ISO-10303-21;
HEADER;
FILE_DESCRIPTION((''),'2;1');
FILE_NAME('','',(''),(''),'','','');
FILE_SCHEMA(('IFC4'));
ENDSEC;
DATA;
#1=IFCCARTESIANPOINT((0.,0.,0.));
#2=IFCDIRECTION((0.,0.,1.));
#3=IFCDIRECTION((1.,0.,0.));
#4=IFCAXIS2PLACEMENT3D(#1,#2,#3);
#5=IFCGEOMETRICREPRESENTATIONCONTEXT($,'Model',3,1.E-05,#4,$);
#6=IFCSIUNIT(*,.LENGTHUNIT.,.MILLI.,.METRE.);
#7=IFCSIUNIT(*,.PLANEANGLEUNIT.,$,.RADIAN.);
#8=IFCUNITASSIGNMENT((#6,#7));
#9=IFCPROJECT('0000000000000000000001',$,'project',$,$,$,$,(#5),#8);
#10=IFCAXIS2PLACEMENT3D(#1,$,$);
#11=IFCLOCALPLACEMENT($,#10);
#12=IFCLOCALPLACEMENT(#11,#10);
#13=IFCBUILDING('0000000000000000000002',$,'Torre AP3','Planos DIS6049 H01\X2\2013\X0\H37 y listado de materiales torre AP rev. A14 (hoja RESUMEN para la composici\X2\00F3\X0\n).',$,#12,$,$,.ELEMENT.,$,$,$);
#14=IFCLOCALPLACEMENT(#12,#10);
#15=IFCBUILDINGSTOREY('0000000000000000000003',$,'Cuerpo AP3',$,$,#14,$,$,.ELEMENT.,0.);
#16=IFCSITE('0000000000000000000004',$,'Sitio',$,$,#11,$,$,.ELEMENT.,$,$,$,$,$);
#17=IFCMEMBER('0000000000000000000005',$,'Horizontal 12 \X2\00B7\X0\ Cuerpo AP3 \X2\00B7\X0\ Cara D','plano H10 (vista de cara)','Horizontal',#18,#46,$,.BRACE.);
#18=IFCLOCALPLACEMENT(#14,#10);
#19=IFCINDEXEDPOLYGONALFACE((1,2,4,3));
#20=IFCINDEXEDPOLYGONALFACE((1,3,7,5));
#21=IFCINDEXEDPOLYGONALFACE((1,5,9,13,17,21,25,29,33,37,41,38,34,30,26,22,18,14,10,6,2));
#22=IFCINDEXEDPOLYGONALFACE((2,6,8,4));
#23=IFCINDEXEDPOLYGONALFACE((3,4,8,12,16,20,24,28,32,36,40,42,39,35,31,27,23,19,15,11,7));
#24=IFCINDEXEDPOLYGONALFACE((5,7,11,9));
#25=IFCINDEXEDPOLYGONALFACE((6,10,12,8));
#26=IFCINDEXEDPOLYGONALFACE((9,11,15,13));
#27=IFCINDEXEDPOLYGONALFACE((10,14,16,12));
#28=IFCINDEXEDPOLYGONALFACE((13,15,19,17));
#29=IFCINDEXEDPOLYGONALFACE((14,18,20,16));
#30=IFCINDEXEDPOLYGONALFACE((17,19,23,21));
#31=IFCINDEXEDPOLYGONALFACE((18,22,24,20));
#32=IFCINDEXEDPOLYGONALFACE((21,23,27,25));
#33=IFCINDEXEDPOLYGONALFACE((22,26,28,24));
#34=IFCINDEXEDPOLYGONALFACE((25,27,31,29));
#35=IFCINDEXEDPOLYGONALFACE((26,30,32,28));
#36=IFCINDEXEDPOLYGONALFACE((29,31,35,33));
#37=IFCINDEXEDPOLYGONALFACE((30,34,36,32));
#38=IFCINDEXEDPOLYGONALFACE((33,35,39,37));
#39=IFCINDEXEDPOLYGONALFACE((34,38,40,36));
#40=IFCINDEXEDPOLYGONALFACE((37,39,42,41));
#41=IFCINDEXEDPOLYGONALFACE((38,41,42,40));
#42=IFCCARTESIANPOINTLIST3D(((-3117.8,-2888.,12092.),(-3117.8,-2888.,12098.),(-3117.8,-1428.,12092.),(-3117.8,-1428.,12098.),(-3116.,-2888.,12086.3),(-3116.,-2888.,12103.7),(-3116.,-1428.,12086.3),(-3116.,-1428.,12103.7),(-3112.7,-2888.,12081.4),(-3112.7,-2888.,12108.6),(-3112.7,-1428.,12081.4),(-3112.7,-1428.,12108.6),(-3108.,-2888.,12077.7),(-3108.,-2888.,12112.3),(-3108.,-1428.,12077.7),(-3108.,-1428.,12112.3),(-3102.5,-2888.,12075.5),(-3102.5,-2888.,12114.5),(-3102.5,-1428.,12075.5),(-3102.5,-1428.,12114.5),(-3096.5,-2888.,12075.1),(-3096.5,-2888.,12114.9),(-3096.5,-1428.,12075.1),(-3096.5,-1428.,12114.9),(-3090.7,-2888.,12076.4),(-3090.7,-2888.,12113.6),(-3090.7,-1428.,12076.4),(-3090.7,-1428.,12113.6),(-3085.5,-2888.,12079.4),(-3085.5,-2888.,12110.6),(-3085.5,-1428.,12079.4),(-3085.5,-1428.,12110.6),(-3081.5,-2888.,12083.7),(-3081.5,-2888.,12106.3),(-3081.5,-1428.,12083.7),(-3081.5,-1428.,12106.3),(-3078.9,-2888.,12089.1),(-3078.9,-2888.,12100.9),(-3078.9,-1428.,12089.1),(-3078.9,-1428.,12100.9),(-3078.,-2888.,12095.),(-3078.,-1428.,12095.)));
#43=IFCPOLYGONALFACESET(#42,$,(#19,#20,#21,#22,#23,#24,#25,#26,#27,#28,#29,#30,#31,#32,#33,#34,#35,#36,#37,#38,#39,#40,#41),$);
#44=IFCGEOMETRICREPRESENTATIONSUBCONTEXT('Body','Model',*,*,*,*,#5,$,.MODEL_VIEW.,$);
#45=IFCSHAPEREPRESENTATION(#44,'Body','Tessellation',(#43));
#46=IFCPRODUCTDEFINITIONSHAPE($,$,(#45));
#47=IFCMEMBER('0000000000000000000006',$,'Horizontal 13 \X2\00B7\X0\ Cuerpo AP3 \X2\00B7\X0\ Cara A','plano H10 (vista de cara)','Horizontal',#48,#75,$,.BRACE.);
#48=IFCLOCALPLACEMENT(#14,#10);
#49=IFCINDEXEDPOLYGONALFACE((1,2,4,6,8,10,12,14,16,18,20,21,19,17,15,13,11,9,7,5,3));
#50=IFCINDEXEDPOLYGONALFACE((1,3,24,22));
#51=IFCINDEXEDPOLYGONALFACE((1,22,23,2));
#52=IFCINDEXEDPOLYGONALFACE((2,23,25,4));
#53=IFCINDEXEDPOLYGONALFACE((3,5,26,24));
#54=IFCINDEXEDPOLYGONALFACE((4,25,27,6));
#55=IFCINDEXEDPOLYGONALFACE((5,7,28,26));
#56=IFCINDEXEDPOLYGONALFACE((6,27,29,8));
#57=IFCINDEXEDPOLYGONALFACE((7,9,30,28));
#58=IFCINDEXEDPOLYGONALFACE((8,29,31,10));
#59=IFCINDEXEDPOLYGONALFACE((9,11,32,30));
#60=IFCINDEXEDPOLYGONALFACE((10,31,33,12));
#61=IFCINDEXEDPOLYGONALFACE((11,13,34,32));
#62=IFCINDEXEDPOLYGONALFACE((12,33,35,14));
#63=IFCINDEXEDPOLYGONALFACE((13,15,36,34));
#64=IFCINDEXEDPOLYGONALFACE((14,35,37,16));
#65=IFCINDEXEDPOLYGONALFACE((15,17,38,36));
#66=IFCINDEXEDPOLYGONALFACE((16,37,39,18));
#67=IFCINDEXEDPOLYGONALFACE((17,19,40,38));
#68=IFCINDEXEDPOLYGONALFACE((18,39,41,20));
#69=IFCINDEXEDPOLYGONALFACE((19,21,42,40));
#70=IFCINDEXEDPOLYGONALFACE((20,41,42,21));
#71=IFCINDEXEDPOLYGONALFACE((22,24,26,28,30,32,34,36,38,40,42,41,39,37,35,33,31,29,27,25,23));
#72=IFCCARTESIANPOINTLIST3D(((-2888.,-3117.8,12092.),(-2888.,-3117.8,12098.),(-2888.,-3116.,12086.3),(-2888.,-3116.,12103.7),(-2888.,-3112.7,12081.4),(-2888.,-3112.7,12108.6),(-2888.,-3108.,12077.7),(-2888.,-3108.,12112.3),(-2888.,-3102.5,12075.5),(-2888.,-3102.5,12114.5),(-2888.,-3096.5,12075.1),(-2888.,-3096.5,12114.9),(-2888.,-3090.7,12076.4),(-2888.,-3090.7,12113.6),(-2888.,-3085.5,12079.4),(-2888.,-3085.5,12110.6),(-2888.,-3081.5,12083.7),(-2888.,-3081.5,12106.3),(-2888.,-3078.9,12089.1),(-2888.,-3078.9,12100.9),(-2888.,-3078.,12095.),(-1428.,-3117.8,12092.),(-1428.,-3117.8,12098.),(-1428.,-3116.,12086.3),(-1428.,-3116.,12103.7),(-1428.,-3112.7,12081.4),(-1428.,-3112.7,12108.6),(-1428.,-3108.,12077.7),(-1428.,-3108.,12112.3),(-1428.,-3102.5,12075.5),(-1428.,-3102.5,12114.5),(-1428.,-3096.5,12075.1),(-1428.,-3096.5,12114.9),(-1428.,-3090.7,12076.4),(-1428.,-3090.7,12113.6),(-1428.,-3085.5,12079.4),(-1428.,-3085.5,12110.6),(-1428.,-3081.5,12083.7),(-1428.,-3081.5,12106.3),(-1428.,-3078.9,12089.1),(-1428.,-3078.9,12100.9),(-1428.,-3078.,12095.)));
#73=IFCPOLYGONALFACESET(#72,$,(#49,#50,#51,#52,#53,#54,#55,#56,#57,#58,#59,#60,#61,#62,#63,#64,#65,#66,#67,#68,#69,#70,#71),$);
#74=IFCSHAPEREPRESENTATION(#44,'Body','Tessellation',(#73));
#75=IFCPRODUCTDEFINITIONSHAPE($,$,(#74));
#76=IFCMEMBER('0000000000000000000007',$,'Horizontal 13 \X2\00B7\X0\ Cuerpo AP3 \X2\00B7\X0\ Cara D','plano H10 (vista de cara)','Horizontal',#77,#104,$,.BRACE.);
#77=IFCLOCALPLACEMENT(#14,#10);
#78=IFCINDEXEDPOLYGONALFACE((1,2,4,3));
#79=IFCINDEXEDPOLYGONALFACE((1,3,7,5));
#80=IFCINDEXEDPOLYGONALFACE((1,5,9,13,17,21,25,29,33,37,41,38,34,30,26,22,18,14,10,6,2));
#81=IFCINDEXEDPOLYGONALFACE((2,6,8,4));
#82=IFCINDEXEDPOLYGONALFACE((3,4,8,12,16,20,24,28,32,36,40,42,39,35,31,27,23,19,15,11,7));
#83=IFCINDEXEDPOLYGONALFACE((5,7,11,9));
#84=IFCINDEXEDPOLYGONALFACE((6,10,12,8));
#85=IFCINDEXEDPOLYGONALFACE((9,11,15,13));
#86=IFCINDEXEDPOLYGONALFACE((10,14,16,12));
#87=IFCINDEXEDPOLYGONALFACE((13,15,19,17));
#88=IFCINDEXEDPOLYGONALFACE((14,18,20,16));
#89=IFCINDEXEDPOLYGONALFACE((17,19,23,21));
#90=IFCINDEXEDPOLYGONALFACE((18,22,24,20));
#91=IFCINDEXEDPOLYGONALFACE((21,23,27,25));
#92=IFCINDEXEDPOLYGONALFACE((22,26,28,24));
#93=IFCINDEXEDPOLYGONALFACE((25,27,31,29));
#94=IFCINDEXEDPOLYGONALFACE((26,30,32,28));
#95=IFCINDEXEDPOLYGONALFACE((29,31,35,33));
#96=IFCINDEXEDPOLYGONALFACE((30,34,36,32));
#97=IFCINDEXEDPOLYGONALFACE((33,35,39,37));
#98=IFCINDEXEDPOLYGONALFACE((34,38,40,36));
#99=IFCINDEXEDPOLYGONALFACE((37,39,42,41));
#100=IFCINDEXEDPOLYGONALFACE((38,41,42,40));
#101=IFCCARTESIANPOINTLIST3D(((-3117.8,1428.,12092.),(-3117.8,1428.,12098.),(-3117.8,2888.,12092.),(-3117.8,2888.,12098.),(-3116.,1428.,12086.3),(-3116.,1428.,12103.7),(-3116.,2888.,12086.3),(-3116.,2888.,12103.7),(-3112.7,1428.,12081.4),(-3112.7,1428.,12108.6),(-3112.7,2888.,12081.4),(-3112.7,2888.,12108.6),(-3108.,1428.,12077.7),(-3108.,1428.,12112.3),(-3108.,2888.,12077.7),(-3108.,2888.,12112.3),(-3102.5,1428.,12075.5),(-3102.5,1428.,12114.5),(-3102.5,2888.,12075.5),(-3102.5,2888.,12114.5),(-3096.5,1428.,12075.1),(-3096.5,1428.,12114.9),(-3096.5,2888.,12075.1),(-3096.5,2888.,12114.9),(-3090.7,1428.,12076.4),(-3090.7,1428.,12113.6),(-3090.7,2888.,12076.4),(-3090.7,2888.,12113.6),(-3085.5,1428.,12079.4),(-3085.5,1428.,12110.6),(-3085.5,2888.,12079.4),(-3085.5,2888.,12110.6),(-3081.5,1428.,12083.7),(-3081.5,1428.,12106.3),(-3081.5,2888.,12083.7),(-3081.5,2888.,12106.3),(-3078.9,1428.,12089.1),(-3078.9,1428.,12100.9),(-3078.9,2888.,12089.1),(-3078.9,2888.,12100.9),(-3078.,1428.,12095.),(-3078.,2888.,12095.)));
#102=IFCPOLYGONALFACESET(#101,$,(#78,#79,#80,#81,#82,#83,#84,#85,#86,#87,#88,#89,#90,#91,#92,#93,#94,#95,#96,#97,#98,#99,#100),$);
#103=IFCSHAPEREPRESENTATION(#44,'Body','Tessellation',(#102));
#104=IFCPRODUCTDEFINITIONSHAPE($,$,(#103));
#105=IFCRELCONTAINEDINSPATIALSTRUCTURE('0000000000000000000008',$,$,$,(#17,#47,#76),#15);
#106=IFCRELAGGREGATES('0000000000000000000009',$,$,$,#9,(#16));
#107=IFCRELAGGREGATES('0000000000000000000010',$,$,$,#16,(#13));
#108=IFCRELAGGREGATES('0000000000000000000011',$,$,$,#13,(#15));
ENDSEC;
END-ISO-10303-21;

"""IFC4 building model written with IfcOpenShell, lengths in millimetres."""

from ifc_helpers import new_model, si_unit, frame, origin, origin_with_axes, place, context, subcontext, project, spatial, circle, extrude, element, save


model = new_model("IFC4")

# Units and contexts
model_context = context("Model", 3, precision=1e-05, world=origin_with_axes())
body_context = subcontext(model_context, "Body", "Model", "MODEL_VIEW")
ifc_project = project(units=[si_unit("LENGTHUNIT", "METRE", prefix="MILLI"), si_unit("PLANEANGLEUNIT", "RADIAN")], contexts=[model_context])

# Site, building, storey
site_placement = place(None, origin())
site = spatial("IfcSite", under=ifc_project, at=site_placement, Name="Sitio", CompositionType="ELEMENT")
building_placement = place(site_placement, origin())
building = spatial("IfcBuilding", under=site, at=building_placement, Name="Torre AP3", Description="Planos DIS6049 H01–H37 y listado de materiales torre AP rev. A14 (hoja RESUMEN para la composición).", CompositionType="ELEMENT")
storey_placement = place(building_placement, origin())
storey = spatial("IfcBuildingStorey", under=building, at=storey_placement, Name="Cuerpo AP3", CompositionType="ELEMENT", Elevation=0.0)

# Members
for number, where, z_axis, x_axis, name in (
    (1, (-3098.0, -2888.0, 12095.0), (0.0, 1.0, 0.0), (1.0, 0.0, 0.0), "Horizontal 12 · Cuerpo AP3 · Cara D"),
    (2, (-1428.0, -3098.0, 12095.0), (-1.0, 0.0, 0.0), (0.0, 1.0, 0.0), "Horizontal 13 · Cuerpo AP3 · Cara A"),
    (3, (-3098.0, 1428.0, 12095.0), (0.0, 1.0, 0.0), (1.0, 0.0, 0.0), "Horizontal 13 · Cuerpo AP3 · Cara D"),
):
    element("IfcMember", number, at=place(storey_placement, frame(where, z_axis=z_axis, x_axis=x_axis)), inside=storey, Name=name, Description="plano H10 (vista de cara)", ObjectType="Horizontal", PredefinedType="BRACE", context=body_context, shape_type="SweptSolid", body=[
        extrude(circle(Radius=20.0), None, (0.0, 0.0, 1.0), 1460.0),
    ])

save(model, "model.ifc")
